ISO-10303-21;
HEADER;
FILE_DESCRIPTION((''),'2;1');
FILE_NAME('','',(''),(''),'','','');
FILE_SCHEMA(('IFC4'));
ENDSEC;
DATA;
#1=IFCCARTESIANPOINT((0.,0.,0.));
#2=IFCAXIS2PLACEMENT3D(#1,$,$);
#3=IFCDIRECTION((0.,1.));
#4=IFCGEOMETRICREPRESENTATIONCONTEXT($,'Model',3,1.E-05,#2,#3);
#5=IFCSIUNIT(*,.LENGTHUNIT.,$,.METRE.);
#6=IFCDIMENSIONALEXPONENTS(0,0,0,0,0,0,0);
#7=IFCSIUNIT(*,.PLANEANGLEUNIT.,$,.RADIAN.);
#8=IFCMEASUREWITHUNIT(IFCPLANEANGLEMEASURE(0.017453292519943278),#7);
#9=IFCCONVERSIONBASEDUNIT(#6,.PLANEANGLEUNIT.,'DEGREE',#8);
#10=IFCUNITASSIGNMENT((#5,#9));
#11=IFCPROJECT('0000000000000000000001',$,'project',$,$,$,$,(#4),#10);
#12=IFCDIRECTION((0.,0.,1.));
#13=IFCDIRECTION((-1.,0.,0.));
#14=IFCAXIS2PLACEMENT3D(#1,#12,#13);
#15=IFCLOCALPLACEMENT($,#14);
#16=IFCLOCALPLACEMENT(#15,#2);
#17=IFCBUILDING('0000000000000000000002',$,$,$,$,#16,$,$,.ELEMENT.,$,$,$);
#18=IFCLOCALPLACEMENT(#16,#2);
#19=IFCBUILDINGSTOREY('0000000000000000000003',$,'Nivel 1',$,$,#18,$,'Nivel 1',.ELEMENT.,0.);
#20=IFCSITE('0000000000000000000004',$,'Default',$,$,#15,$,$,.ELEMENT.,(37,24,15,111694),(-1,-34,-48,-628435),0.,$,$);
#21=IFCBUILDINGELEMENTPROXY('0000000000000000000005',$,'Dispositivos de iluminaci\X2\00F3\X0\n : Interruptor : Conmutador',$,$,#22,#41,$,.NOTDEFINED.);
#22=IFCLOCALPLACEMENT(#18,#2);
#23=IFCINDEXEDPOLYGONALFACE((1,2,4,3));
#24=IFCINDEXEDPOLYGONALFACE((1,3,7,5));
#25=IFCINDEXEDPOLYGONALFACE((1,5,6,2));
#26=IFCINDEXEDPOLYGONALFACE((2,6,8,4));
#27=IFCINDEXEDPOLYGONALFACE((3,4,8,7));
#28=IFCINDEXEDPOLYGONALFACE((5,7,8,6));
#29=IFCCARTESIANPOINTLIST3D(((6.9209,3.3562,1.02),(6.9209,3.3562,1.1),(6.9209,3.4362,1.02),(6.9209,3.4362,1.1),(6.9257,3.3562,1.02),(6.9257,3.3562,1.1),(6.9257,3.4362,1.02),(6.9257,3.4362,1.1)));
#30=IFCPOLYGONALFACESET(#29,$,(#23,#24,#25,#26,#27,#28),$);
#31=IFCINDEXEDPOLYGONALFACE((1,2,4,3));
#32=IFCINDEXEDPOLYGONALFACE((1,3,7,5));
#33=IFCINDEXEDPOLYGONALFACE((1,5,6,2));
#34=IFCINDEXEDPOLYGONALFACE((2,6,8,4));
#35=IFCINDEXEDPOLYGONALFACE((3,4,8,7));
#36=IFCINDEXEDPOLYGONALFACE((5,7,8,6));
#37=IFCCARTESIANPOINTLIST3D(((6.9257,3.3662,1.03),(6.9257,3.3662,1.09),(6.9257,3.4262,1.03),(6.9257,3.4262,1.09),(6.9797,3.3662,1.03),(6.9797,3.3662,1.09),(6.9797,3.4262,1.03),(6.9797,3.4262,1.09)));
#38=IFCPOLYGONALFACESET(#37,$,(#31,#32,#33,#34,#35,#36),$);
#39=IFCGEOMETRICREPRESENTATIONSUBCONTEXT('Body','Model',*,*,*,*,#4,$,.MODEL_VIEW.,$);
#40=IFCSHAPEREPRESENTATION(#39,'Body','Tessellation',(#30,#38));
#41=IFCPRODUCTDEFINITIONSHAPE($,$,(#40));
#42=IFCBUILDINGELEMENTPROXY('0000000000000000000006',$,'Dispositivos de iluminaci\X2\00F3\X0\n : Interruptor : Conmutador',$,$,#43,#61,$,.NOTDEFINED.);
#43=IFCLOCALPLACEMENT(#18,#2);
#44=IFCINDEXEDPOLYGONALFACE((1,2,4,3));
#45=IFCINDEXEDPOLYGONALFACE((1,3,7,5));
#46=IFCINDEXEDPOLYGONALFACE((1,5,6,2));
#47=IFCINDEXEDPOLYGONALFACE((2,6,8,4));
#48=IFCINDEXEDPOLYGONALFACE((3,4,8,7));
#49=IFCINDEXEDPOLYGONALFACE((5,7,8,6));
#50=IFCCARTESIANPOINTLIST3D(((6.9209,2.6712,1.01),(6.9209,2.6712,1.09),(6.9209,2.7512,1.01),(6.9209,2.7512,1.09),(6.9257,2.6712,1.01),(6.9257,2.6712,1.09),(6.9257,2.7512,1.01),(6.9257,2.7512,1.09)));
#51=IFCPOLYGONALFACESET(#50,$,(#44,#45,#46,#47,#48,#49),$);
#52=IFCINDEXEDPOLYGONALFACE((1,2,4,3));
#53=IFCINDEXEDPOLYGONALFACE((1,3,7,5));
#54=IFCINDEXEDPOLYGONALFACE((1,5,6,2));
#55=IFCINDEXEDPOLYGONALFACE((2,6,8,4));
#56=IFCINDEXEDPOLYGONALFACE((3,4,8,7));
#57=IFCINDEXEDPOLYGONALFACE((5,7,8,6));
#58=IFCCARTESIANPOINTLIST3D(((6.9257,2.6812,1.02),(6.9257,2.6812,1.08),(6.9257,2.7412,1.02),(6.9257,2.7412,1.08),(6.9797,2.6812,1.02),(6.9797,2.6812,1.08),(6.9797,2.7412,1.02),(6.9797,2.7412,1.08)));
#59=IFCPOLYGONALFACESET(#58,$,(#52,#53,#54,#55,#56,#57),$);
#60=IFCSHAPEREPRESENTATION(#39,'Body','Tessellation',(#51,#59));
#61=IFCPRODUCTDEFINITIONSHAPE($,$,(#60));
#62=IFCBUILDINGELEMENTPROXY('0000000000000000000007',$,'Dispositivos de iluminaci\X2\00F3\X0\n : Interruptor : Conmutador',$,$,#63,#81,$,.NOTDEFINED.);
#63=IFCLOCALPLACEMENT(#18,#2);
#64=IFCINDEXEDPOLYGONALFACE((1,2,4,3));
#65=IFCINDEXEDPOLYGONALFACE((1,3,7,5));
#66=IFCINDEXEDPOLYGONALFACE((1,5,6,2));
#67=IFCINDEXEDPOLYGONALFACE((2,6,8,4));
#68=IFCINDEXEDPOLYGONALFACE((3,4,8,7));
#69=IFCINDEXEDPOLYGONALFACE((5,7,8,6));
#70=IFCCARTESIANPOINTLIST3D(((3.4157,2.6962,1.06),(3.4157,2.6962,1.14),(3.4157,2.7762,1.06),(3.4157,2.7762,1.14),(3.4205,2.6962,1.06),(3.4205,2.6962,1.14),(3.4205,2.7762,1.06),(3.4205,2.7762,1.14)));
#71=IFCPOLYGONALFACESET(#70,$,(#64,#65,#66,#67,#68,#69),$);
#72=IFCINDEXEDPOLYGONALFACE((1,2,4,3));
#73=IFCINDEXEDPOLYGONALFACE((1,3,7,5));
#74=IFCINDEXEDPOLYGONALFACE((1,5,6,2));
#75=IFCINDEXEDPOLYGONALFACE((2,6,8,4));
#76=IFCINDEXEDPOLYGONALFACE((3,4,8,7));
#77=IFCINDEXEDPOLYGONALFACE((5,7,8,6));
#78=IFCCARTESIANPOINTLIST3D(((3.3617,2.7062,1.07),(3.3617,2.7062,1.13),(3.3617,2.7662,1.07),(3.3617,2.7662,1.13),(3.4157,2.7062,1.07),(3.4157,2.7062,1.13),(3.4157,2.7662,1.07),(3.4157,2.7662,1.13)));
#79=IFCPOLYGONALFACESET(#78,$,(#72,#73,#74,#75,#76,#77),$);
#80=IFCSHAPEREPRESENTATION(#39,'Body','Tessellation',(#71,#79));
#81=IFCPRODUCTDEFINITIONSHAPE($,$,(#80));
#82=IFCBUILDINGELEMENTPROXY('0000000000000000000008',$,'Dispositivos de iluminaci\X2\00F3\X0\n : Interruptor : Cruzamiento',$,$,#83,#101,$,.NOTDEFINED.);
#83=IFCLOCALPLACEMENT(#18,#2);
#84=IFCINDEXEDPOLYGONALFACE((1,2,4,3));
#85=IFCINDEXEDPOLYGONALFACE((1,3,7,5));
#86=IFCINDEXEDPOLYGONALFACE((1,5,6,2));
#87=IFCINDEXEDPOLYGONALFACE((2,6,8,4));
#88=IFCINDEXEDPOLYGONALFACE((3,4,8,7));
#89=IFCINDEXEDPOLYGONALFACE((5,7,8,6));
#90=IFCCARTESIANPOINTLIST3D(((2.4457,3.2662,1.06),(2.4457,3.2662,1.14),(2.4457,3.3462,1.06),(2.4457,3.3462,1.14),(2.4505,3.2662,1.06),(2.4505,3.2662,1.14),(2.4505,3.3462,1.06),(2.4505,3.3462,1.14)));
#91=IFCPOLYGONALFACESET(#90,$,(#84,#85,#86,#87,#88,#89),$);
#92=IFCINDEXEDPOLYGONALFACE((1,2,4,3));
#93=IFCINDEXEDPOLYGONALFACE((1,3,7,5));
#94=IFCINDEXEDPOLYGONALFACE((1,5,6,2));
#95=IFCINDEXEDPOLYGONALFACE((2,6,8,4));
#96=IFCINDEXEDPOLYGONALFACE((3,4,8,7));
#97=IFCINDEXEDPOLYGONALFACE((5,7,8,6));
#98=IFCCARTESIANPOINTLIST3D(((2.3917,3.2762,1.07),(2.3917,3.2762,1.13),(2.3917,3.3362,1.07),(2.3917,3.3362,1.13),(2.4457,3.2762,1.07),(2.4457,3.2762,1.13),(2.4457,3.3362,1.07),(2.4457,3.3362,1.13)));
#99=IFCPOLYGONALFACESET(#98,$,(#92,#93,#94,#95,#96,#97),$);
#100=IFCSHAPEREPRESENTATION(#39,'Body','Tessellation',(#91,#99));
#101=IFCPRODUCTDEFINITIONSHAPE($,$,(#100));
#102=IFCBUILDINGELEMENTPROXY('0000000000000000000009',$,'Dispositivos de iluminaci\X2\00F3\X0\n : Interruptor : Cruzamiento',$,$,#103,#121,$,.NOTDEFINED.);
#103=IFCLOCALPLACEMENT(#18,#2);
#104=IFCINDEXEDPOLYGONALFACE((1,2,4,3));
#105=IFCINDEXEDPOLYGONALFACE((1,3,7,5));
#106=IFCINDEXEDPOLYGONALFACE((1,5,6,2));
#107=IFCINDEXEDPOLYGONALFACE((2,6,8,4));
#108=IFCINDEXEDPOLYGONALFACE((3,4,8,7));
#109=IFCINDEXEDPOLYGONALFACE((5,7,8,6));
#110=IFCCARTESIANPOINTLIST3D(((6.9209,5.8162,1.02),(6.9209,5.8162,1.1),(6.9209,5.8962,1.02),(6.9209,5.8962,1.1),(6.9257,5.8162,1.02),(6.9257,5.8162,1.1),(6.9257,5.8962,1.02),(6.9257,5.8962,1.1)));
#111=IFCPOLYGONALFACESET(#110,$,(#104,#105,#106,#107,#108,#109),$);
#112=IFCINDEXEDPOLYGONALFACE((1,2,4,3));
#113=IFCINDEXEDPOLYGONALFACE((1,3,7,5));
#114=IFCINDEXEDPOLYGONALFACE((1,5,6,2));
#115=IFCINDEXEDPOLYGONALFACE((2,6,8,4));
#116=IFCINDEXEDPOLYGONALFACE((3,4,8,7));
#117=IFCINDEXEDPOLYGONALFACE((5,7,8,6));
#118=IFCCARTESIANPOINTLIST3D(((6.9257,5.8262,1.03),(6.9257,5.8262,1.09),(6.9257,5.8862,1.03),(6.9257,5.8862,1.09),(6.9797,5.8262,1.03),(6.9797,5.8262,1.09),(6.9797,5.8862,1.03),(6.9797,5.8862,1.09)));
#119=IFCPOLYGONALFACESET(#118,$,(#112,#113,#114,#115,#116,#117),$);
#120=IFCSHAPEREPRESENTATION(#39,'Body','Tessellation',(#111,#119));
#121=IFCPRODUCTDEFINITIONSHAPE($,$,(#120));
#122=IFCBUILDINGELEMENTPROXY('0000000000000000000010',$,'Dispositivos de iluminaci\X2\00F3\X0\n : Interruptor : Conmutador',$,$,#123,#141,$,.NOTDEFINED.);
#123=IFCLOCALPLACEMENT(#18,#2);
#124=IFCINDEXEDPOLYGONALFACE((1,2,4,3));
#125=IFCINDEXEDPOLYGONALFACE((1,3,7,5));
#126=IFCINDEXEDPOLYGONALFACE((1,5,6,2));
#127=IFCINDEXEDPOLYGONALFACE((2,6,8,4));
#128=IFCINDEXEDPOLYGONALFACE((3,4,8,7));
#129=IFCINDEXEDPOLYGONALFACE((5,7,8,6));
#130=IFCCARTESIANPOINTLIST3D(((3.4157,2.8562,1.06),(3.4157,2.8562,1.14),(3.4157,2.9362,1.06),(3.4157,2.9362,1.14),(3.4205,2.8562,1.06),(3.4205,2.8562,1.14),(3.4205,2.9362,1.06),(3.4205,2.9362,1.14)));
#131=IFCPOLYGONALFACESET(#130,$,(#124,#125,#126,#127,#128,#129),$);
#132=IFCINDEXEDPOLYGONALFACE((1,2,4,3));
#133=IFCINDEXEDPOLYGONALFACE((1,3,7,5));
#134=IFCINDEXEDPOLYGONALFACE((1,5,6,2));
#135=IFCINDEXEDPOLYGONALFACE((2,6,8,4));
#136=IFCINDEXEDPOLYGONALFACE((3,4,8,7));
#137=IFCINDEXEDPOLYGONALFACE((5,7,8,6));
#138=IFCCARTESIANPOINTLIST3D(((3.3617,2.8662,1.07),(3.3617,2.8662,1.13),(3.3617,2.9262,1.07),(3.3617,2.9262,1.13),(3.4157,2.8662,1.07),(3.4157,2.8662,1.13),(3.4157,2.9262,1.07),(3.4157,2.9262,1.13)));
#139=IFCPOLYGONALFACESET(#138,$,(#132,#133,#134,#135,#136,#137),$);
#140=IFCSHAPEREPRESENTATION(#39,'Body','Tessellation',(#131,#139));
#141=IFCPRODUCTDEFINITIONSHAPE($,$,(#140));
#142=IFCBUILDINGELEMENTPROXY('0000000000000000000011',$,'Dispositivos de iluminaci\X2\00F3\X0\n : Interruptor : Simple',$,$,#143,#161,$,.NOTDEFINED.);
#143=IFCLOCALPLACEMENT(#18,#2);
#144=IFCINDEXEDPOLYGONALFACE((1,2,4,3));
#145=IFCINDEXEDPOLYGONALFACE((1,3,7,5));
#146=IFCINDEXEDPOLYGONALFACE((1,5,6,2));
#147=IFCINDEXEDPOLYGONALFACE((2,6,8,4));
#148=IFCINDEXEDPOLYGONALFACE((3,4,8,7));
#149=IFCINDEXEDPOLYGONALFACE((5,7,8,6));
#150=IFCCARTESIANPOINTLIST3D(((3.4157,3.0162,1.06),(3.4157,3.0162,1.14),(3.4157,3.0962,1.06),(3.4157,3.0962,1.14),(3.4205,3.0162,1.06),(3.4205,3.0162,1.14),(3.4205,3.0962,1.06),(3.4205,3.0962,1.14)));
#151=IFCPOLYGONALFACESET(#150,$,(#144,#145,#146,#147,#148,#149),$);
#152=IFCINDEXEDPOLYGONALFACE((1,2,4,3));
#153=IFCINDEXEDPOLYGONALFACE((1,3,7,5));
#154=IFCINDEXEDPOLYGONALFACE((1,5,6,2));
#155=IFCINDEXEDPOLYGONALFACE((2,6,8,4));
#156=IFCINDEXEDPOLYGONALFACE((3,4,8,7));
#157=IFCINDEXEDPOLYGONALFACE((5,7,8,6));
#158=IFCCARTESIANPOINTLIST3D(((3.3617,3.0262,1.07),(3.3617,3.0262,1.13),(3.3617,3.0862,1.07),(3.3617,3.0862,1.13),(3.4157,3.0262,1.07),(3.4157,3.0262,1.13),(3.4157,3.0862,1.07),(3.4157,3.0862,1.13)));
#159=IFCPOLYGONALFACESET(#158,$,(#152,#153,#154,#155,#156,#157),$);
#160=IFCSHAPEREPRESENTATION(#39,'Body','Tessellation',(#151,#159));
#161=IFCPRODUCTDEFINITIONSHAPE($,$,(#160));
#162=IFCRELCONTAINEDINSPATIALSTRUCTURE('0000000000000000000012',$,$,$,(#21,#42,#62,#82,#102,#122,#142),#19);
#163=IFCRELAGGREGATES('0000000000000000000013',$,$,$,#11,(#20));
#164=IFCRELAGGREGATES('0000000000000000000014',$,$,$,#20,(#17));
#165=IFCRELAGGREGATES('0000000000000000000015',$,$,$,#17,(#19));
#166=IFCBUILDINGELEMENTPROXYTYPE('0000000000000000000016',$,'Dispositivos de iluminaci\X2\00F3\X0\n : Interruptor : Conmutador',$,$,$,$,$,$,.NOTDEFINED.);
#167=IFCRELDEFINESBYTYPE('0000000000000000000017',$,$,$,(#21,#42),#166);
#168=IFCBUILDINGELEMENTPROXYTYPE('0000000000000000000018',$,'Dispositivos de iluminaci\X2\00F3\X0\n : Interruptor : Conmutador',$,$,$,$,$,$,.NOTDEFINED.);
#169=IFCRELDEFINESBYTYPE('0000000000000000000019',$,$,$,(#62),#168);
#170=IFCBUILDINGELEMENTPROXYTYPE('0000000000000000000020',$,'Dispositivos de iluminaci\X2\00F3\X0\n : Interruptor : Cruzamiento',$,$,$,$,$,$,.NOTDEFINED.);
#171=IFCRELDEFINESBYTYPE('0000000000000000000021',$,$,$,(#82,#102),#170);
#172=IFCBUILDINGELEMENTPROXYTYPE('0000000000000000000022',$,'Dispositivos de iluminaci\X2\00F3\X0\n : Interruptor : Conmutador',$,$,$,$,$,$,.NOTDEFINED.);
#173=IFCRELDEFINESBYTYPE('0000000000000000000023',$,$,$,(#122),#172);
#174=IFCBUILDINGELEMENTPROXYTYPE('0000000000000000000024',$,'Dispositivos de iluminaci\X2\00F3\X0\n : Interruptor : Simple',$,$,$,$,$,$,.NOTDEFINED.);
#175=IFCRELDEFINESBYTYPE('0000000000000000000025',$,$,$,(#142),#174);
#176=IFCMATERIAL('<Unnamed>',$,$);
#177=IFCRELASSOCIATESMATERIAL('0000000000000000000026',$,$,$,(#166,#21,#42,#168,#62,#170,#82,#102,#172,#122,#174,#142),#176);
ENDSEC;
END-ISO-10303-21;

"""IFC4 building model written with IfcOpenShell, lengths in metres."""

from ifc_helpers import new_model, entity, si_unit, converted_unit, direction, frame, origin, place, context, subcontext, project, spatial, indexed_curve, outline, extrude, source, transform, mapped, material, type_object, type_shapes, element, save


model = new_model("IFC4")

# Units and contexts
model_context = context("Model", 3, precision=1e-05, world=origin(), true_north=direction((0.0, 1.0)))
body_context = subcontext(model_context, "Body", "Model", "MODEL_VIEW")
ifc_project = project(units=[si_unit("LENGTHUNIT", "METRE"), converted_unit("PLANEANGLEUNIT", "DEGREE", entity("IfcPlaneAngleMeasure", 0.017453292519943278), si_unit("PLANEANGLEUNIT", "RADIAN"), dimensions=[0, 0, 0, 0, 0, 0, 0])], contexts=[model_context])

# Site, building, storey
site_placement = place(None, frame((0.0, 0.0, 0.0), z_axis=(0.0, 0.0, 1.0), x_axis=(-1.0, 0.0, 0.0)))
site = spatial("IfcSite", under=ifc_project, at=site_placement, Name="Default", CompositionType="ELEMENT", RefLatitude=(37, 24, 15, 111694), RefLongitude=(-1, -34, -48, -628435), RefElevation=0.0)
building_placement = place(site_placement, origin())
building = spatial("IfcBuilding", under=site, at=building_placement, CompositionType="ELEMENT")
storey_placement = place(building_placement, origin())
storey = spatial("IfcBuildingStorey", under=building, at=storey_placement, Name="Nivel 1", LongName="Nivel 1", CompositionType="ELEMENT", Elevation=0.0)

# Shared definitions
ifc_material_1 = material(Name="<Unnamed>")

# Building element proxies
building_element_proxy_type_1 = type_object("IfcBuildingElementProxyType", Name="Dispositivos de iluminación : Interruptor : Conmutador", PredefinedType="NOTDEFINED", material=ifc_material_1)
shared_shape_1 = source(origin(), body_context, "Body", "SweptSolid", [
    extrude(outline(indexed_curve([(-0.04, -0.04), (0.04, -0.04), (0.04, 0.04), (-0.04, 0.04), (-0.04, -0.04)], self_intersect=False)), frame((0.0, 0.0, 0.0), z_axis=(0.0, 0.0, 1.0), x_axis=(0.0, -1.0, 0.0)), (0.0, 0.0, 1.0), 0.0048),
    extrude(outline(indexed_curve([(-0.03, -0.03), (0.03, -0.03), (0.03, 0.03), (-0.03, 0.03), (-0.03, -0.03)], self_intersect=False)), frame((0.0, 0.0, -0.054), z_axis=(0.0, 0.0, 1.0), x_axis=(-1.0, 0.0, 0.0)), (0.0, 0.0, 1.0), 0.054),
])
type_shapes(building_element_proxy_type_1, [shared_shape_1])
for number, where, z_axis, x_axis, name in (
    (1, (6.9257, 3.3962, 1.06), (-1.0, 0.0, 0.0), (0.0, -1.0, 0.0), "Dispositivos de iluminación : Interruptor : Conmutador"),
    (2, (6.9257, 2.7112, 1.05), (-1.0, 0.0, 0.0), (0.0, -1.0, 0.0), "Dispositivos de iluminación : Interruptor : Conmutador"),
):
    element("IfcBuildingElementProxy", number, at=place(storey_placement, frame(where, z_axis=z_axis, x_axis=x_axis)), inside=storey, type_object=building_element_proxy_type_1, material=ifc_material_1, Name=name, PredefinedType="NOTDEFINED", context=body_context, shape_type="MappedRepresentation", body=[
        mapped(shared_shape_1, transform((0.0, 0.0, 0.0), scale=1.0)),
    ])
building_element_proxy_type_2 = type_object("IfcBuildingElementProxyType", Name="Dispositivos de iluminación : Interruptor : Conmutador", PredefinedType="NOTDEFINED", material=ifc_material_1)
shared_shape_2 = source(origin(), body_context, "Body", "SweptSolid", [
    extrude(outline(indexed_curve([(-0.04, -0.04), (0.04, -0.04), (0.04, 0.04), (-0.04, 0.04), (-0.04, -0.04)], self_intersect=False)), frame((0.0, 0.0, 0.0), z_axis=(0.0, 0.0, 1.0), x_axis=(0.0, -1.0, 0.0)), (0.0, 0.0, 1.0), 0.0048),
    extrude(outline(indexed_curve([(-0.03, -0.03), (0.03, -0.03), (0.03, 0.03), (-0.03, 0.03), (-0.03, -0.03)], self_intersect=False)), frame((0.0, 0.0, -0.054), z_axis=(0.0, 0.0, 1.0), x_axis=(-1.0, 0.0, 0.0)), (0.0, 0.0, 1.0), 0.054),
])
type_shapes(building_element_proxy_type_2, [shared_shape_2])
proxy_1_placement = place(storey_placement, frame((3.4157, 2.7362, 1.1), z_axis=(1.0, 0.0, 0.0), x_axis=(0.0, 1.0, 0.0)))
element("IfcBuildingElementProxy", 3, at=proxy_1_placement, inside=storey, type_object=building_element_proxy_type_2, material=ifc_material_1, Name="Dispositivos de iluminación : Interruptor : Conmutador", PredefinedType="NOTDEFINED", context=body_context, shape_type="MappedRepresentation", body=[
    mapped(shared_shape_2, transform((0.0, 0.0, 0.0), scale=1.0)),
])
building_element_proxy_type_3 = type_object("IfcBuildingElementProxyType", Name="Dispositivos de iluminación : Interruptor : Cruzamiento", PredefinedType="NOTDEFINED", material=ifc_material_1)
shared_shape_3 = source(origin(), body_context, "Body", "SweptSolid", [
    extrude(outline(indexed_curve([(-0.04, -0.04), (0.04, -0.04), (0.04, 0.04), (-0.04, 0.04), (-0.04, -0.04)], self_intersect=False)), frame((0.0, 0.0, 0.0), z_axis=(0.0, 0.0, 1.0), x_axis=(0.0, -1.0, 0.0)), (0.0, 0.0, 1.0), 0.0048),
    extrude(outline(indexed_curve([(-0.03, -0.03), (0.03, -0.03), (0.03, 0.03), (-0.03, 0.03), (-0.03, -0.03)], self_intersect=False)), frame((0.0, 0.0, -0.054), z_axis=(0.0, 0.0, 1.0), x_axis=(-1.0, 0.0, 0.0)), (0.0, 0.0, 1.0), 0.054),
])
type_shapes(building_element_proxy_type_3, [shared_shape_3])
for number, where, z_axis, x_axis, name in (
    (4, (2.4457, 3.3062, 1.1), (1.0, 0.0, 0.0), (0.0, 1.0, 0.0), "Dispositivos de iluminación : Interruptor : Cruzamiento"),
    (5, (6.9257, 5.8562, 1.06), (-1.0, 0.0, 0.0), (0.0, -1.0, 0.0), "Dispositivos de iluminación : Interruptor : Cruzamiento"),
):
    element("IfcBuildingElementProxy", number, at=place(storey_placement, frame(where, z_axis=z_axis, x_axis=x_axis)), inside=storey, type_object=building_element_proxy_type_3, material=ifc_material_1, Name=name, PredefinedType="NOTDEFINED", context=body_context, shape_type="MappedRepresentation", body=[
        mapped(shared_shape_3, transform((0.0, 0.0, 0.0), scale=1.0)),
    ])
building_element_proxy_type_4 = type_object("IfcBuildingElementProxyType", Name="Dispositivos de iluminación : Interruptor : Conmutador", PredefinedType="NOTDEFINED", material=ifc_material_1)
shared_shape_4 = source(origin(), body_context, "Body", "SweptSolid", [
    extrude(outline(indexed_curve([(-0.04, -0.04), (0.04, -0.04), (0.04, 0.04), (-0.04, 0.04), (-0.04, -0.04)], self_intersect=False)), frame((0.0, 0.0, 0.0), z_axis=(0.0, 0.0, 1.0), x_axis=(0.0, -1.0, 0.0)), (0.0, 0.0, 1.0), 0.0048),
    extrude(outline(indexed_curve([(-0.03, -0.03), (0.03, -0.03), (0.03, 0.03), (-0.03, 0.03), (-0.03, -0.03)], self_intersect=False)), frame((0.0, 0.0, -0.054), z_axis=(0.0, 0.0, 1.0), x_axis=(-1.0, 0.0, 0.0)), (0.0, 0.0, 1.0), 0.054),
])
type_shapes(building_element_proxy_type_4, [shared_shape_4])
proxy_2_placement = place(storey_placement, frame((3.4157, 2.8962, 1.1), z_axis=(1.0, 0.0, 0.0), x_axis=(0.0, 1.0, 0.0)))
element("IfcBuildingElementProxy", 6, at=proxy_2_placement, inside=storey, type_object=building_element_proxy_type_4, material=ifc_material_1, Name="Dispositivos de iluminación : Interruptor : Conmutador", PredefinedType="NOTDEFINED", context=body_context, shape_type="MappedRepresentation", body=[
    mapped(shared_shape_4, transform((0.0, 0.0, 0.0), scale=1.0)),
])
building_element_proxy_type_5 = type_object("IfcBuildingElementProxyType", Name="Dispositivos de iluminación : Interruptor : Simple", PredefinedType="NOTDEFINED", material=ifc_material_1)
shared_shape_5 = source(origin(), body_context, "Body", "SweptSolid", [
    extrude(outline(indexed_curve([(-0.04, -0.04), (0.04, -0.04), (0.04, 0.04), (-0.04, 0.04), (-0.04, -0.04)], self_intersect=False)), frame((0.0, 0.0, 0.0), z_axis=(0.0, 0.0, 1.0), x_axis=(0.0, -1.0, 0.0)), (0.0, 0.0, 1.0), 0.0048),
    extrude(outline(indexed_curve([(-0.03, -0.03), (0.03, -0.03), (0.03, 0.03), (-0.03, 0.03), (-0.03, -0.03)], self_intersect=False)), frame((0.0, 0.0, -0.054), z_axis=(0.0, 0.0, 1.0), x_axis=(-1.0, 0.0, 0.0)), (0.0, 0.0, 1.0), 0.054),
])
type_shapes(building_element_proxy_type_5, [shared_shape_5])
proxy_3_placement = place(storey_placement, frame((3.4157, 3.0562, 1.1), z_axis=(1.0, 0.0, 0.0), x_axis=(0.0, 1.0, 0.0)))
element("IfcBuildingElementProxy", 7, at=proxy_3_placement, inside=storey, type_object=building_element_proxy_type_5, material=ifc_material_1, Name="Dispositivos de iluminación : Interruptor : Simple", PredefinedType="NOTDEFINED", context=body_context, shape_type="MappedRepresentation", body=[
    mapped(shared_shape_5, transform((0.0, 0.0, 0.0), scale=1.0)),
])

save(model, "model.ifc")
